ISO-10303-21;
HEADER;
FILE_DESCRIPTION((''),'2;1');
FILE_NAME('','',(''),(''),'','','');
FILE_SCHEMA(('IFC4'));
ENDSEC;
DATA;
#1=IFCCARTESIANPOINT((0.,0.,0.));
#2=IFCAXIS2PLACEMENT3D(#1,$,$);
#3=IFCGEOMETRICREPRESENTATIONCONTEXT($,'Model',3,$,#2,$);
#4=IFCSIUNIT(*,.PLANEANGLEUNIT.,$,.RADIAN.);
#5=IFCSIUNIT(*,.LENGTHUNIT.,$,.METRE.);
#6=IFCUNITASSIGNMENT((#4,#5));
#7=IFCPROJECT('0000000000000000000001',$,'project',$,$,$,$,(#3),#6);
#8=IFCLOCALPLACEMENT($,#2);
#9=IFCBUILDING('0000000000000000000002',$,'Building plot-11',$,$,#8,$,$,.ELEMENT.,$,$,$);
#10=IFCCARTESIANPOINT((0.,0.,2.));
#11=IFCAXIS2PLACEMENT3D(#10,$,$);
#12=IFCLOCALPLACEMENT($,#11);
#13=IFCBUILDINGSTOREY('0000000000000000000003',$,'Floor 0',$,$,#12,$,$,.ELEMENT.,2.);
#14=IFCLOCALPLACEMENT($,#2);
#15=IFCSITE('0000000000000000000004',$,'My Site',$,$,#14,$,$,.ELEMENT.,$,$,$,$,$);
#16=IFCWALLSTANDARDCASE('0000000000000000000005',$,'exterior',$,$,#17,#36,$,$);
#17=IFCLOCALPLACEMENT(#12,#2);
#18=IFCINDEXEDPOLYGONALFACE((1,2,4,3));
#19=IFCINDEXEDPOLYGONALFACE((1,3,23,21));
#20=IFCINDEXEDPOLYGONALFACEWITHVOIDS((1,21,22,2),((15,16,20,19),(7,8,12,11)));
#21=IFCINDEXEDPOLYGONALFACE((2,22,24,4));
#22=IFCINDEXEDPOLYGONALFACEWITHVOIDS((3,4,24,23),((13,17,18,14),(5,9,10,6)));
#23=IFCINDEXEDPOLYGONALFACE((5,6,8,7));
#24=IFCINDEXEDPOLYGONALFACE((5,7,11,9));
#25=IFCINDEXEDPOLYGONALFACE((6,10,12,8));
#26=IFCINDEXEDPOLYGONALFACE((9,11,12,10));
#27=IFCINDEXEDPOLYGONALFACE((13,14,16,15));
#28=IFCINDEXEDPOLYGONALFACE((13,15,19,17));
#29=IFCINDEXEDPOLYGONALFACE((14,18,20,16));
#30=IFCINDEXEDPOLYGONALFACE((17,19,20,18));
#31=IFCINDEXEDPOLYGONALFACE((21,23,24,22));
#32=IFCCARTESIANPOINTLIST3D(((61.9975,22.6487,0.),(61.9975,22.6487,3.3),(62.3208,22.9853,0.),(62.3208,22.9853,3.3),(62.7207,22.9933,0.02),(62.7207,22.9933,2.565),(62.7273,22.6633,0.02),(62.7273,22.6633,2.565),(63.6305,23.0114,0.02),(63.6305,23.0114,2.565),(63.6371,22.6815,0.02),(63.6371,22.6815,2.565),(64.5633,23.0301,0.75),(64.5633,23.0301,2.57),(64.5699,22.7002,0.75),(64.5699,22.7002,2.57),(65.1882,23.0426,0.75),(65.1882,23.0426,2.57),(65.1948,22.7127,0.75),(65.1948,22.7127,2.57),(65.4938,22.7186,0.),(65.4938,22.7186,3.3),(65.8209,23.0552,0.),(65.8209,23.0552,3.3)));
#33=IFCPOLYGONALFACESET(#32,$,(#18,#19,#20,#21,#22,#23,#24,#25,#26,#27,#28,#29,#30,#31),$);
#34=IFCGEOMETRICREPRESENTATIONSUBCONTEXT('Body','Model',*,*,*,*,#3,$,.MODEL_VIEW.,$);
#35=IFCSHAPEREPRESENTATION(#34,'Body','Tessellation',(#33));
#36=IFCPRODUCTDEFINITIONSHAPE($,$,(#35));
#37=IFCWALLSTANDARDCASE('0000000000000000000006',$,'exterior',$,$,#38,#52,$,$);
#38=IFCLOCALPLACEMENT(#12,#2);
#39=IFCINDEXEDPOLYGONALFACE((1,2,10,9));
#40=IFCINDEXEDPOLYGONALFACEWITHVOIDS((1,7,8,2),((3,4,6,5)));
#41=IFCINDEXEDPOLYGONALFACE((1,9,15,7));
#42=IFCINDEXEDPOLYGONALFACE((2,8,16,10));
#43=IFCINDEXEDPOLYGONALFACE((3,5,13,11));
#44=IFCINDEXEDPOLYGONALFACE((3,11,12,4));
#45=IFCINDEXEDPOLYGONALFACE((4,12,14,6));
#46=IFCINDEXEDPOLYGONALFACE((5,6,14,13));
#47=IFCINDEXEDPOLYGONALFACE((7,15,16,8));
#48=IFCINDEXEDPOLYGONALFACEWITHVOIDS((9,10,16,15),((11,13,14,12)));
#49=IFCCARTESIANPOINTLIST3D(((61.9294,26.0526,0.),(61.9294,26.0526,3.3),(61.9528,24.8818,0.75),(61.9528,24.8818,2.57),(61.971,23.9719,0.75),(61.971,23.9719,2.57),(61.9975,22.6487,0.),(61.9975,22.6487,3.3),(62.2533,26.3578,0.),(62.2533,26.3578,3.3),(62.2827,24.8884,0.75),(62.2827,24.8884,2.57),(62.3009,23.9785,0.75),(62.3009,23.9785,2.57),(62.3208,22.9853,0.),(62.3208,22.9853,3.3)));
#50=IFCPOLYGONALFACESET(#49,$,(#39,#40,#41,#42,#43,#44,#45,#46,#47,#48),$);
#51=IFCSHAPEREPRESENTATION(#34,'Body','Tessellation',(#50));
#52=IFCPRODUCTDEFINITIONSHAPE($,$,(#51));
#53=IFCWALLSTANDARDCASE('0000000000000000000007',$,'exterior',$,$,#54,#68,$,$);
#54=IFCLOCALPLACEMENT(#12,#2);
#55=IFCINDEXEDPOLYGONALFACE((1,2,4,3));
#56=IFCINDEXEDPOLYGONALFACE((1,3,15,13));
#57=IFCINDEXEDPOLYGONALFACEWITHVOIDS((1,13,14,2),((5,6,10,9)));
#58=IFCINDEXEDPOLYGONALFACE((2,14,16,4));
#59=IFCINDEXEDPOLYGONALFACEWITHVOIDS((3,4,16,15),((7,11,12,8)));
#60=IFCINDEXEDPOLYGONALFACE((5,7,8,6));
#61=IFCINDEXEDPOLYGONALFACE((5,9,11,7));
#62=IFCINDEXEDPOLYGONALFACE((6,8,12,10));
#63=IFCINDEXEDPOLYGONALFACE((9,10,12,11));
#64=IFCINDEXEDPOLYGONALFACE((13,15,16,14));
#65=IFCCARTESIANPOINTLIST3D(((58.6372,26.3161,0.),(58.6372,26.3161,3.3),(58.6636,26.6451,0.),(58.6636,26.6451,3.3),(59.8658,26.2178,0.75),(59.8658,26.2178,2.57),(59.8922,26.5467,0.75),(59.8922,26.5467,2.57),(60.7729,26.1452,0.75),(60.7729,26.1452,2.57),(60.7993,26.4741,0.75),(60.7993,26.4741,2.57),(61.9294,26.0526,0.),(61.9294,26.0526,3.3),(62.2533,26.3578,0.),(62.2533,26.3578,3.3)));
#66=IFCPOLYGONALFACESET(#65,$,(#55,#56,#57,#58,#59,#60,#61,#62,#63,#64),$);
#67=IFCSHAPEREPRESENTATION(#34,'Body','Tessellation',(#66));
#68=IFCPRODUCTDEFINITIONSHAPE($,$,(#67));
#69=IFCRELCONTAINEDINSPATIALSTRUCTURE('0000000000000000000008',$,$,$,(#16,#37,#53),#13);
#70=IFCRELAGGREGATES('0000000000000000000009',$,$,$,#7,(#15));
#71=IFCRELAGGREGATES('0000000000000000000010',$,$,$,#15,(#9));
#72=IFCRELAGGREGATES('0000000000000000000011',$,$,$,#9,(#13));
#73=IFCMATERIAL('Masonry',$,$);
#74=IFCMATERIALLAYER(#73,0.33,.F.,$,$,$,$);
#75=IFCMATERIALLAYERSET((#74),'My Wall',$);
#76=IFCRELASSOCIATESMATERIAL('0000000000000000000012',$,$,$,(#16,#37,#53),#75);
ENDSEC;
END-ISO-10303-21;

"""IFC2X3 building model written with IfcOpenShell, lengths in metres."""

from ifc_helpers import new_model, si_unit, frame, origin, place, context, subcontext, project, spatial, polyline, outline, extrude, material, layer, layer_set, layer_usage, element, save


model = new_model("IFC2X3")

# Units and contexts
model_context = context("Model", 3, world=origin())
body_context = subcontext(model_context, "Body", "Model", "MODEL_VIEW")
ifc_project = project(units=[si_unit("PLANEANGLEUNIT", "RADIAN"), si_unit("LENGTHUNIT", "METRE")], contexts=[model_context])

# Site, building, storey
site_placement = place(None, origin())
site = spatial("IfcSite", under=ifc_project, at=site_placement, Name="My Site", CompositionType="ELEMENT")
building_placement = place(None, origin())
building = spatial("IfcBuilding", under=site, at=building_placement, Name="Building plot-11", CompositionType="ELEMENT")
storey_placement = place(None, frame((0.0, 0.0, 2.0)))
storey = spatial("IfcBuildingStorey", under=building, at=storey_placement, Name="Floor 0", CompositionType="ELEMENT", Elevation=2.0)

# Shared definitions
ifc_material = material(Name="Masonry")
ifc_layer = layer(ifc_material, 0.33, ventilated=False)
ifc_layer_set = layer_set([ifc_layer], Name="My Wall")
ifc_layer_usage = layer_usage(ifc_layer_set, "AXIS2", "NEGATIVE", 0.08)

# Wall, openings
wall_1_placement = place(storey_placement, origin())
wall_1 = element("IfcWallStandardCase", 1, at=wall_1_placement, inside=storey, material=ifc_layer_usage, Name="exterior", context=body_context, shape_type="SweptSolid", body=[
    extrude(outline(polyline([(65.4938, 22.7186), (65.8209, 23.0552), (62.3208, 22.9853), (61.9975, 22.6487), (65.4938, 22.7186)])), origin(), (0.0, 0.0, 1.0), 3.3),
])
opening_1_placement = place(storey_placement, frame((0.0, 0.0, 0.75)))
element("IfcOpeningElement", 2, at=opening_1_placement, cuts=wall_1, ObjectType="Opening", context=body_context, shape_type="SweptSolid", body=[
    extrude(outline(polyline([(65.1882, 23.0426), (64.5633, 23.0301), (64.5699, 22.7002), (65.1948, 22.7127), (65.1882, 23.0426)])), origin(), (0.0, 0.0, 1.0), 1.82),
])
opening_2_placement = place(storey_placement, frame((0.0, 0.0, 0.02)))
element("IfcOpeningElement", 3, at=opening_2_placement, cuts=wall_1, ObjectType="Opening", context=body_context, shape_type="SweptSolid", body=[
    extrude(outline(polyline([(63.6305, 23.0114), (62.7207, 22.9933), (62.7273, 22.6633), (63.6371, 22.6815), (63.6305, 23.0114)])), origin(), (0.0, 0.0, 1.0), 2.545),
])

# Walls, openings
wall_2_placement = place(storey_placement, origin())
wall_2 = element("IfcWallStandardCase", 4, at=wall_2_placement, inside=storey, material=ifc_layer_usage, Name="exterior", context=body_context, shape_type="SweptSolid", body=[
    extrude(outline(polyline([(61.9975, 22.6487), (62.3208, 22.9853), (62.2533, 26.3578), (61.9294, 26.0526), (61.9975, 22.6487)])), origin(), (0.0, 0.0, 1.0), 3.3),
])
opening_3_placement = place(storey_placement, frame((0.0, 0.0, 0.75)))
element("IfcOpeningElement", 5, at=opening_3_placement, cuts=wall_2, ObjectType="Opening", context=body_context, shape_type="SweptSolid", body=[
    extrude(outline(polyline([(62.3009, 23.9785), (62.2827, 24.8884), (61.9528, 24.8818), (61.971, 23.9719), (62.3009, 23.9785)])), origin(), (0.0, 0.0, 1.0), 1.82),
])
wall_3_placement = place(storey_placement, origin())
wall_3 = element("IfcWallStandardCase", 6, at=wall_3_placement, inside=storey, material=ifc_layer_usage, Name="exterior", context=body_context, shape_type="SweptSolid", body=[
    extrude(outline(polyline([(61.9294, 26.0526), (62.2533, 26.3578), (58.6636, 26.6451), (58.6372, 26.3161), (61.9294, 26.0526)])), origin(), (0.0, 0.0, 1.0), 3.3),
])
opening_4_placement = place(storey_placement, frame((0.0, 0.0, 0.75)))
element("IfcOpeningElement", 7, at=opening_4_placement, cuts=wall_3, ObjectType="Opening", context=body_context, shape_type="SweptSolid", body=[
    extrude(outline(polyline([(60.7993, 26.4741), (59.8922, 26.5467), (59.8658, 26.2178), (60.7729, 26.1452), (60.7993, 26.4741)])), origin(), (0.0, 0.0, 1.0), 1.82),
])

save(model, "model.ifc")
